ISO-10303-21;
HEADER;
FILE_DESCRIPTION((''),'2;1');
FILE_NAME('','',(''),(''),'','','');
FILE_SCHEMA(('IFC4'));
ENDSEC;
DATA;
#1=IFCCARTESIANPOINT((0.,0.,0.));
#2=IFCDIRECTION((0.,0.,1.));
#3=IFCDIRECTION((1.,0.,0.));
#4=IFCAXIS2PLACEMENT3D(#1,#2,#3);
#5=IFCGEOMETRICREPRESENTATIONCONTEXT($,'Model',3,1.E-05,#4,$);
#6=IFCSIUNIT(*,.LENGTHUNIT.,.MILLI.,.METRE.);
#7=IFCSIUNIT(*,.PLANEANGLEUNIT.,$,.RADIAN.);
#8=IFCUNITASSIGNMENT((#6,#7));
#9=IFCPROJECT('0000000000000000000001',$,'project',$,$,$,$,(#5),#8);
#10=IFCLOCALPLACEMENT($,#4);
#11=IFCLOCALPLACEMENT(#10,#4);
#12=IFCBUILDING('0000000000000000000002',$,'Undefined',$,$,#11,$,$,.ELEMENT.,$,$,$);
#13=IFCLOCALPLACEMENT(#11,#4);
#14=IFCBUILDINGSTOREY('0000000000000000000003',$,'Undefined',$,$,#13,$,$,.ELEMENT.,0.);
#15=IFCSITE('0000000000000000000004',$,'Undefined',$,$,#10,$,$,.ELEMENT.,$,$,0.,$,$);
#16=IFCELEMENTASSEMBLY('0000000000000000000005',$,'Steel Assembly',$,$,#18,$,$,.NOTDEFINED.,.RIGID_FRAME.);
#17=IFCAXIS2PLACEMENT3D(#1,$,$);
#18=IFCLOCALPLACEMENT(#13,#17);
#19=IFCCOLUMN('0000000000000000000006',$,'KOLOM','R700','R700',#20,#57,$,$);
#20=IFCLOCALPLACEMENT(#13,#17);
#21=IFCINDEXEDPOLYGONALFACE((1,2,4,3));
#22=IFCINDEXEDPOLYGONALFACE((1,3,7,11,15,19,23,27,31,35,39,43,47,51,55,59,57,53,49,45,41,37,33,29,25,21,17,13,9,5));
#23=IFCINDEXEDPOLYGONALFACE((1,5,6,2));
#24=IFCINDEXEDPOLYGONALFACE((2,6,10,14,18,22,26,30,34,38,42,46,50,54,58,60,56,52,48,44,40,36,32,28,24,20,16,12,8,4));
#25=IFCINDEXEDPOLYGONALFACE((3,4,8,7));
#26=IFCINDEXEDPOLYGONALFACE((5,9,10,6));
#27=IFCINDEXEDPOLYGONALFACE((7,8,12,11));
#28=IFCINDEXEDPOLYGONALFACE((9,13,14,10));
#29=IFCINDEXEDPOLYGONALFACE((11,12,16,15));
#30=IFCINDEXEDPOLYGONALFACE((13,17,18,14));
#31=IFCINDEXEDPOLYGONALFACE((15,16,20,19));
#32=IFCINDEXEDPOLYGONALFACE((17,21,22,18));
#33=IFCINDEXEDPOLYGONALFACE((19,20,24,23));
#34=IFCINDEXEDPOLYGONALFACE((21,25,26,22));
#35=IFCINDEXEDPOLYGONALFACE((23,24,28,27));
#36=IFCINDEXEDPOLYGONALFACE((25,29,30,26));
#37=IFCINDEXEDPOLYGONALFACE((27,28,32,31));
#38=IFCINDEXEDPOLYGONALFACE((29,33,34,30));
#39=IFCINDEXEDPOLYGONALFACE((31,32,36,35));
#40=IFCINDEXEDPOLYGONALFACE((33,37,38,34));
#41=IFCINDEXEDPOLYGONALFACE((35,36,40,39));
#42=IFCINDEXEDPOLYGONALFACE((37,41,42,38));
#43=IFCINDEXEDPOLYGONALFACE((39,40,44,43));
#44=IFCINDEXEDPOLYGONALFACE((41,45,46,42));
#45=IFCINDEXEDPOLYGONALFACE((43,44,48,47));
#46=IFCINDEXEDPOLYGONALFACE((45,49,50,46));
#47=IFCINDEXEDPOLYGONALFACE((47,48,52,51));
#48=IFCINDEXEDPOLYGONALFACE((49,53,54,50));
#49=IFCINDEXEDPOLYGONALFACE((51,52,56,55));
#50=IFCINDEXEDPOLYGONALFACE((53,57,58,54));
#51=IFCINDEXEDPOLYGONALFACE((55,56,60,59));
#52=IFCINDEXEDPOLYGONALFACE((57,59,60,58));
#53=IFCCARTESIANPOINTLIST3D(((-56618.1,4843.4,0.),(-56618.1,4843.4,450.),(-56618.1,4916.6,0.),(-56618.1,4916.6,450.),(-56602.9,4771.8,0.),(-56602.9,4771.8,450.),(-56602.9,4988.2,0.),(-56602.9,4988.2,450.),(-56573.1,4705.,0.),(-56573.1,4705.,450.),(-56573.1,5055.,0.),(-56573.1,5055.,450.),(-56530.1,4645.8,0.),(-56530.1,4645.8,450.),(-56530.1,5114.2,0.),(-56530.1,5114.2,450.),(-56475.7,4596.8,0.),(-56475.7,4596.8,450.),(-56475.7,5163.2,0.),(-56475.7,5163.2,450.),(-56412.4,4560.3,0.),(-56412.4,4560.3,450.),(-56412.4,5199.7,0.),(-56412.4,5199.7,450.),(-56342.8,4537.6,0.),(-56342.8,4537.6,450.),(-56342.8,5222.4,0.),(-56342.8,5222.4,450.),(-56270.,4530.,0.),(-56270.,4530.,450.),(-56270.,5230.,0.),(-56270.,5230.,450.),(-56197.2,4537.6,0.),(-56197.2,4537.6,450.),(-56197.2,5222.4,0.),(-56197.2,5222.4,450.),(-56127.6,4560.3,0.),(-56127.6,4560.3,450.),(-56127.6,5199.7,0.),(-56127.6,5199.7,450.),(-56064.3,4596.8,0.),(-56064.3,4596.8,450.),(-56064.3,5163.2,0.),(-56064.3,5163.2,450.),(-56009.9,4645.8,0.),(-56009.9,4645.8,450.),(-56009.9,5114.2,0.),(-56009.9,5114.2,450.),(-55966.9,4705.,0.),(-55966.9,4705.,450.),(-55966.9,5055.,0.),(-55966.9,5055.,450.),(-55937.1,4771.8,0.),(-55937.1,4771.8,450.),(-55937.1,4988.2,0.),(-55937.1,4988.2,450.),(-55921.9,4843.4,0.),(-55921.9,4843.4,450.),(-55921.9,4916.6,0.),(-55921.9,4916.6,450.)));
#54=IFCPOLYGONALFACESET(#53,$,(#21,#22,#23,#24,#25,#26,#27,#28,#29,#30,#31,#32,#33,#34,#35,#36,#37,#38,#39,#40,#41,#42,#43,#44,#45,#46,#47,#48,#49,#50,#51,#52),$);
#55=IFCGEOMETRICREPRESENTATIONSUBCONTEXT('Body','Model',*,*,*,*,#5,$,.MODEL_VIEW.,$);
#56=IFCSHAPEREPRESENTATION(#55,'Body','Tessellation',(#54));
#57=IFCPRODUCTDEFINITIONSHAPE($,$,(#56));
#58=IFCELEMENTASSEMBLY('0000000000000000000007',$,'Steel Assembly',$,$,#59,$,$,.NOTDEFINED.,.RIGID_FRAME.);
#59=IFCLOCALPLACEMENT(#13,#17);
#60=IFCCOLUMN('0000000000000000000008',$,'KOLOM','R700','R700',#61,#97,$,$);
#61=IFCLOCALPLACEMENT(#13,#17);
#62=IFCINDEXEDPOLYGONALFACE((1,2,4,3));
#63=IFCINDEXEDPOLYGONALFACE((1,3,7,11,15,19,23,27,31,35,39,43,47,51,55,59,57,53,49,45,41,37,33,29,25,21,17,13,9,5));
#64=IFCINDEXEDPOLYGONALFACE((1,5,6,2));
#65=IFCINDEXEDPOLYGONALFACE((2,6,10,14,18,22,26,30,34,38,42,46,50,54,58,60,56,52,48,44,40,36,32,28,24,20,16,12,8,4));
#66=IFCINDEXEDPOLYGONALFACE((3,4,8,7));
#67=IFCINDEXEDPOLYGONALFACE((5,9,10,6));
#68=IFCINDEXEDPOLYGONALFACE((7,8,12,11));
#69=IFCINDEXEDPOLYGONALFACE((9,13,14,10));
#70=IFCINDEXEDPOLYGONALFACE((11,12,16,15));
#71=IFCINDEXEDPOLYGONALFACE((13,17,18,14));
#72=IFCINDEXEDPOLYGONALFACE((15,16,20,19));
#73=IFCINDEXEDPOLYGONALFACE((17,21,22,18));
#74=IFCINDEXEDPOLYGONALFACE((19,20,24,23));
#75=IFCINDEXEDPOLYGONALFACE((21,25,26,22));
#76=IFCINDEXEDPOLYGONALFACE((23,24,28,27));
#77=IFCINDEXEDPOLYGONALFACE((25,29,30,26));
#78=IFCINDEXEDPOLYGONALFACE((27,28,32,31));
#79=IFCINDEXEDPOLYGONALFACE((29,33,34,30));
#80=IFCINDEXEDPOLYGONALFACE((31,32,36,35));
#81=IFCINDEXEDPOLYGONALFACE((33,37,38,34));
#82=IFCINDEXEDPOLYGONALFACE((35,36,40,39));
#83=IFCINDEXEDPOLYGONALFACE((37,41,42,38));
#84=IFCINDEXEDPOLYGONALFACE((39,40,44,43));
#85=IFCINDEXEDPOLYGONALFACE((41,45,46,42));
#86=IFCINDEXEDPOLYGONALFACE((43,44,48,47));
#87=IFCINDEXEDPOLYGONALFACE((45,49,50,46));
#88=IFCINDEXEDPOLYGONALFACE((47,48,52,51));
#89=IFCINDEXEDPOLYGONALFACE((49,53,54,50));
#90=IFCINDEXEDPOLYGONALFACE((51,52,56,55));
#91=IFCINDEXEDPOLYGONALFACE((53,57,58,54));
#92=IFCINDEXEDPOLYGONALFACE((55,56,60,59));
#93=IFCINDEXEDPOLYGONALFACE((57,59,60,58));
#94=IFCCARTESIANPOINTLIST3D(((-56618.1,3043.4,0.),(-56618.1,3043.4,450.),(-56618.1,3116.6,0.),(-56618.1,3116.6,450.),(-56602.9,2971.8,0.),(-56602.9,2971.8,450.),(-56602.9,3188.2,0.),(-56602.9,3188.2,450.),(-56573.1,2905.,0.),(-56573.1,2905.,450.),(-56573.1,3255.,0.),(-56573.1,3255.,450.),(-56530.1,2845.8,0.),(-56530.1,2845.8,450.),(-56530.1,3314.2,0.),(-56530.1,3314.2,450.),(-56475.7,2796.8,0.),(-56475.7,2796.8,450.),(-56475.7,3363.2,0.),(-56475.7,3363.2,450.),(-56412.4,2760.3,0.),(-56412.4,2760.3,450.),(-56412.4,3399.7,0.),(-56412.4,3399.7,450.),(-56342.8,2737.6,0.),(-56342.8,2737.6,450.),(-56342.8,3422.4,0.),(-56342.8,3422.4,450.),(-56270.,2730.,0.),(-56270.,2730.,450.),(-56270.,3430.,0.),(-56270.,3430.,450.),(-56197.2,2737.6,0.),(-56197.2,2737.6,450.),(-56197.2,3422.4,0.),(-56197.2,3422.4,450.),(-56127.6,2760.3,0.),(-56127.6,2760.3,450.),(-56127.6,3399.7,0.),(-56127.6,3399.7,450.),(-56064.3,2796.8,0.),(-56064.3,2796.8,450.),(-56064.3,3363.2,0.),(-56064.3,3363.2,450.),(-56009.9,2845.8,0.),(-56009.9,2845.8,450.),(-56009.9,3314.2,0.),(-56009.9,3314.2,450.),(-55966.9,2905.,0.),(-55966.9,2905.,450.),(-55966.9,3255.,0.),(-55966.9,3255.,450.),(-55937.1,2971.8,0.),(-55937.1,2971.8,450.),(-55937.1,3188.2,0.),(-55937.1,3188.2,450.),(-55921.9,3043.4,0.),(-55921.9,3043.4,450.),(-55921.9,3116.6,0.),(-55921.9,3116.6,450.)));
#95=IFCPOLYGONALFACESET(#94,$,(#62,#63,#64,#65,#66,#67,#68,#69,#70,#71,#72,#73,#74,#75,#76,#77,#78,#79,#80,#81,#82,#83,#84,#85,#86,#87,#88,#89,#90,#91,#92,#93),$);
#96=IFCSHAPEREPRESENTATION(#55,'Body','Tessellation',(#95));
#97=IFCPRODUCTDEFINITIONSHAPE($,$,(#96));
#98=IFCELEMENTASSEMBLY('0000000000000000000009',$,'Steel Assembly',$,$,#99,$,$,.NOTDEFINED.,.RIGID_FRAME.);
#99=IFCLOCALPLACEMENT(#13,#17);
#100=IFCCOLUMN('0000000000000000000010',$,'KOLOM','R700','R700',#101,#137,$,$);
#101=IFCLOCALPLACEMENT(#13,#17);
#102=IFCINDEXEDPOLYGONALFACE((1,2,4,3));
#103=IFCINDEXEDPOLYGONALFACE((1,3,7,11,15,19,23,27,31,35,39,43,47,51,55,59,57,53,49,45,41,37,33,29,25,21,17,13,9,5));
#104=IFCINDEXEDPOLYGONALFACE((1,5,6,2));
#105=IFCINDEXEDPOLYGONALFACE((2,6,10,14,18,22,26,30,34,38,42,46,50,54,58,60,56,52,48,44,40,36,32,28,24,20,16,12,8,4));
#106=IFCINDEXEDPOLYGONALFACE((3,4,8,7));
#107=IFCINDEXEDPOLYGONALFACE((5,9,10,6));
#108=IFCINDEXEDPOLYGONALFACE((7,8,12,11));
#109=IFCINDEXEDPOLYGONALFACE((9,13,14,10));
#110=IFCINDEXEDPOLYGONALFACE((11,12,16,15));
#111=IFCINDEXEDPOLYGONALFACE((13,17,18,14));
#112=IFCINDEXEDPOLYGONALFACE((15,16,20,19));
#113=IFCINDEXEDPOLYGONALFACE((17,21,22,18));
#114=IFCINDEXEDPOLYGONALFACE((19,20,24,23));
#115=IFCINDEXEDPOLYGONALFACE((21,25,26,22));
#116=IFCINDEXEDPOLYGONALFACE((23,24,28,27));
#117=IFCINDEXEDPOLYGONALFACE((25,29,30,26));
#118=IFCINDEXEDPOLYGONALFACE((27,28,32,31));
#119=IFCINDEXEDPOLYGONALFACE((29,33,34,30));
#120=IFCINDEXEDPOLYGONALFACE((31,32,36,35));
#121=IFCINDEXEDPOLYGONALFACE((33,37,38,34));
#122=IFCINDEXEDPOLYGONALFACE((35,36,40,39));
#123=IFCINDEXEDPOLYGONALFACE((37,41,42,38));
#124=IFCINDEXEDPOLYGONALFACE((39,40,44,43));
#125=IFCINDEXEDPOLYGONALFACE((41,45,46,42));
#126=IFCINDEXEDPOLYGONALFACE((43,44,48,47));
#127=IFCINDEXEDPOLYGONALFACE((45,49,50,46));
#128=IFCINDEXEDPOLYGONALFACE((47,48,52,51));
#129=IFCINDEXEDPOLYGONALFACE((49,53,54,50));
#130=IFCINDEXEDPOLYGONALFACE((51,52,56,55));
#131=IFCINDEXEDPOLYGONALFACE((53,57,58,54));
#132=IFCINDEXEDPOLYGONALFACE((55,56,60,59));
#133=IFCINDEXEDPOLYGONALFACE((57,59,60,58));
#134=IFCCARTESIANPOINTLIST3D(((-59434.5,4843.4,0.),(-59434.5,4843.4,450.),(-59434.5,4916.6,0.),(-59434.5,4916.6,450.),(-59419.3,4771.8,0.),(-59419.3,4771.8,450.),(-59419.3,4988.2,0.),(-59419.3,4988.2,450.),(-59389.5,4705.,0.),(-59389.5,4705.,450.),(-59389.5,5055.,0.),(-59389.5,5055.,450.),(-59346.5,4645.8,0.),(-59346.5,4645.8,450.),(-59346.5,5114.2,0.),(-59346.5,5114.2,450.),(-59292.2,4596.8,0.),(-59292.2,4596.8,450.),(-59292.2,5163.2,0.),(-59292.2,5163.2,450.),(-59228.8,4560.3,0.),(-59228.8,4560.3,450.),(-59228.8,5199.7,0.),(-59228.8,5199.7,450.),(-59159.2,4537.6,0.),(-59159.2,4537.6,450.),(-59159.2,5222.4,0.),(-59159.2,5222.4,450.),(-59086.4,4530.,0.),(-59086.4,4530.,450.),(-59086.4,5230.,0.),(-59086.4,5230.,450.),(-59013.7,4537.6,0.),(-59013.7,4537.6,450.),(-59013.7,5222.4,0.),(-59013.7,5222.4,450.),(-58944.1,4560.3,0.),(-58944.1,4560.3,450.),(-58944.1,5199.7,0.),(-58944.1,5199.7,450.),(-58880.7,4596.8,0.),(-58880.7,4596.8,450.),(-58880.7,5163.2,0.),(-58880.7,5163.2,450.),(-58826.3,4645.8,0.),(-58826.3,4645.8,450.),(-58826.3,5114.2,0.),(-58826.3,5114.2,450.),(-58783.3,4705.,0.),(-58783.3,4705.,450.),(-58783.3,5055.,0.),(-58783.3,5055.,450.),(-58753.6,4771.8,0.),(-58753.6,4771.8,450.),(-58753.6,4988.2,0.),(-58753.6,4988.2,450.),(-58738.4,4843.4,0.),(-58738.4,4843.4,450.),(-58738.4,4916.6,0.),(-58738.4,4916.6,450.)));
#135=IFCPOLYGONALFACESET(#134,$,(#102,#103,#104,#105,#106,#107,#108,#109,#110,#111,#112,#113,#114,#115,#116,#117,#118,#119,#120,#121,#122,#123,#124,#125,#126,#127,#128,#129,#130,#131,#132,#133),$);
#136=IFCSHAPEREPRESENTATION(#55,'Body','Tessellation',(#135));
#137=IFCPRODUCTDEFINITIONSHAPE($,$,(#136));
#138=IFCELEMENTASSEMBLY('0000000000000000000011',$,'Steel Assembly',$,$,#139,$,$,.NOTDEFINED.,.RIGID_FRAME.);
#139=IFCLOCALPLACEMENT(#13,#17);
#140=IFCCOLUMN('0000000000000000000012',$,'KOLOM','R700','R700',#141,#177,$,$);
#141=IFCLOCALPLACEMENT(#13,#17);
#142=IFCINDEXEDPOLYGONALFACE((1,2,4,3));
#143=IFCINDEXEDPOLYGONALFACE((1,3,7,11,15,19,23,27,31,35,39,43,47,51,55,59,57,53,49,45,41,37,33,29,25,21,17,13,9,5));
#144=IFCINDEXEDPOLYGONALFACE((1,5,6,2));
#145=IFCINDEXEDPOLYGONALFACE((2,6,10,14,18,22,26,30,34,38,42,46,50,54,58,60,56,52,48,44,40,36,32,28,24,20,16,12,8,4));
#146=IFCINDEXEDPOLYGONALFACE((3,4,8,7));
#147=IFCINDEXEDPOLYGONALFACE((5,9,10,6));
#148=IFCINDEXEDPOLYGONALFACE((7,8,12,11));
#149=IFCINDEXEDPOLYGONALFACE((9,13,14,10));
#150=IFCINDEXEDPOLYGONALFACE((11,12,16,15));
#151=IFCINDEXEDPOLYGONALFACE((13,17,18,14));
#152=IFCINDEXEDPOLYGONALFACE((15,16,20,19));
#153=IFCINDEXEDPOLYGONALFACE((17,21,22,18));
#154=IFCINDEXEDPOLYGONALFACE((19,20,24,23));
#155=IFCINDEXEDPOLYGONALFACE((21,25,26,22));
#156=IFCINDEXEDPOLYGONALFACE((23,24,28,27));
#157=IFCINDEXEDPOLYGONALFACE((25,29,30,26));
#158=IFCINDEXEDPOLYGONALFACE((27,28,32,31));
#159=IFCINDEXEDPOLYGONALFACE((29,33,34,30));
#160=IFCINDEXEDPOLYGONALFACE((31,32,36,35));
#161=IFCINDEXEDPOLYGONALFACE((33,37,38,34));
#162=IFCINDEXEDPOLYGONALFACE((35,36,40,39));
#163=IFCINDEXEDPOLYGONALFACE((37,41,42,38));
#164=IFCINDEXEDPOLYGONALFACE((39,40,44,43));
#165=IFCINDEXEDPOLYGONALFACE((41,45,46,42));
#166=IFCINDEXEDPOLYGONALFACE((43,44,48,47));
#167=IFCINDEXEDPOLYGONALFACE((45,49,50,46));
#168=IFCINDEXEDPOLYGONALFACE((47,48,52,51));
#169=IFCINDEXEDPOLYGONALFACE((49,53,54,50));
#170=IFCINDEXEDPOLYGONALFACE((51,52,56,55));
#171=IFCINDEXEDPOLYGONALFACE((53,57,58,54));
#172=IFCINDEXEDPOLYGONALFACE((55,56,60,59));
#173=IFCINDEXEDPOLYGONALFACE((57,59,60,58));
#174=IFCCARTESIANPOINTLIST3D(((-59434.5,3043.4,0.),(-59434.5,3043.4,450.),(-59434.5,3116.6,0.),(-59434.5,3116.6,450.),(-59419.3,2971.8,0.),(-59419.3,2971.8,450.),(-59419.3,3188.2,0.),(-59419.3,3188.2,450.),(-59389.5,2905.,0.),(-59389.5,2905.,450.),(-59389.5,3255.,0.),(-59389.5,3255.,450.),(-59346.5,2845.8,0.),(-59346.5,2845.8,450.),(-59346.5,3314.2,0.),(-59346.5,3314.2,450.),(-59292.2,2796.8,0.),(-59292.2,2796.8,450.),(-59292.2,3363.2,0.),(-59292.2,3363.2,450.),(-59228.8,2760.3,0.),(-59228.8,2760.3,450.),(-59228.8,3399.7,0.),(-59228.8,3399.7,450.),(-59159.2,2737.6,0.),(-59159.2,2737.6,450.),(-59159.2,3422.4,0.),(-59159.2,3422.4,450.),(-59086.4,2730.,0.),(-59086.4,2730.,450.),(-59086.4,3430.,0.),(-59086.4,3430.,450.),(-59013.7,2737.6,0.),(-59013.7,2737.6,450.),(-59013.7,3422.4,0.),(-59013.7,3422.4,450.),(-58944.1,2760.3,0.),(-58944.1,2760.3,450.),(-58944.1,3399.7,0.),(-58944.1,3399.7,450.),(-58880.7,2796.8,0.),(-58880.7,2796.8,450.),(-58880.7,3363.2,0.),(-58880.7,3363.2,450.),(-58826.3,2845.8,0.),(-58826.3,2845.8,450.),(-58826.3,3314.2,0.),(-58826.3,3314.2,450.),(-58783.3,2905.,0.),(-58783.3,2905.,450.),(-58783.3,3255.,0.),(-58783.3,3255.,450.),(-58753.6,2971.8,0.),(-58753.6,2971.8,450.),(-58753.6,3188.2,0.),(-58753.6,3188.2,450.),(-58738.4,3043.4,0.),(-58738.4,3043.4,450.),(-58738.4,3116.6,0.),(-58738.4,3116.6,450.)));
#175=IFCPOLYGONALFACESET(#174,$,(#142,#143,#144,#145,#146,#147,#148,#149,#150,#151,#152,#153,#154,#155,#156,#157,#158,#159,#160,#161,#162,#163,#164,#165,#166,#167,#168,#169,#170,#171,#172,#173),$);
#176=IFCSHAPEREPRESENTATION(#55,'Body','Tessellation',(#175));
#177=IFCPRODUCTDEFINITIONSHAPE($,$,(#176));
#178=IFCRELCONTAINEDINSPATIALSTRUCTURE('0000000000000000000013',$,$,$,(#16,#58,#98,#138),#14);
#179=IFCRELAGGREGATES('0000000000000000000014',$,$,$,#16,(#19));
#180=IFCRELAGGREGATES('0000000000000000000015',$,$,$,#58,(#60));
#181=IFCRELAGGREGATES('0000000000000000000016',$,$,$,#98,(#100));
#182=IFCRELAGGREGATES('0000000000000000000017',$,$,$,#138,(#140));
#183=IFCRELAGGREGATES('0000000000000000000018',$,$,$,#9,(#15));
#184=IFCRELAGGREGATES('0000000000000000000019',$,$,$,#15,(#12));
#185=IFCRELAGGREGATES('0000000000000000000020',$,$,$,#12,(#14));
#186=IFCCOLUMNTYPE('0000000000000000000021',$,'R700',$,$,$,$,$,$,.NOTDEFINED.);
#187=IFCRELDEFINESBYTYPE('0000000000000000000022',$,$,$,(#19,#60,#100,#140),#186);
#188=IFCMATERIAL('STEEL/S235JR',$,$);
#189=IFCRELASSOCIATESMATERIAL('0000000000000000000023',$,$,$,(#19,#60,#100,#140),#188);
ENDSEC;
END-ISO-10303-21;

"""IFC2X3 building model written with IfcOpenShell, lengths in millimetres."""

from ifc_helpers import new_model, si_unit, frame, origin_with_axes, origin_2d_with_axis, place, context, subcontext, project, spatial, circle, extrude, material, type_object, element, aggregate, save


model = new_model("IFC2X3")

# Units and contexts
model_context = context("Model", 3, precision=1e-05, world=origin_with_axes())
body_context = subcontext(model_context, "Body", "Model", "MODEL_VIEW")
ifc_project = project(units=[si_unit("LENGTHUNIT", "METRE", prefix="MILLI"), si_unit("PLANEANGLEUNIT", "RADIAN")], contexts=[model_context])

# Site, building, storey
site_placement = place(None, origin_with_axes())
site = spatial("IfcSite", under=ifc_project, at=site_placement, Name="Undefined", CompositionType="ELEMENT", RefElevation=0.0)
building_placement = place(site_placement, origin_with_axes())
building = spatial("IfcBuilding", under=site, at=building_placement, Name="Undefined", CompositionType="ELEMENT")
storey_placement = place(building_placement, origin_with_axes())
storey = spatial("IfcBuildingStorey", under=building, at=storey_placement, Name="Undefined", CompositionType="ELEMENT", Elevation=0.0)

# Element assemblies, columns
ifc_material = material(Name="STEEL/S235JR")
column_type = type_object("IfcColumnType", Name="R700", PredefinedType="NOTDEFINED")
assembly_1_placement = place(storey_placement, origin_with_axes())
assembly_1 = element("IfcElementAssembly", 1, at=assembly_1_placement, inside=storey, Name="Steel Assembly", AssemblyPlace="NOTDEFINED", PredefinedType="RIGID_FRAME")
column_1_placement = place(assembly_1_placement, frame((-56270.0, 4880.0, 0.0), z_axis=(0.0, 0.0, 1.0), x_axis=(-1.0, 0.0, 0.0)))
column_1 = element("IfcColumn", 2, at=column_1_placement, type_object=column_type, material=ifc_material, Name="KOLOM", Description="R700", ObjectType="R700", context=body_context, shape_type="SweptSolid", body=[
    extrude(circle(Radius=350.0, at=origin_2d_with_axis()), frame((0.0, 0.0, 450.0), z_axis=(0.0, 0.0, -1.0), x_axis=(0.0, 1.0, 0.0)), (0.0, 0.0, 1.0), 450.0),
])
aggregate(assembly_1, [column_1])
assembly_2_placement = place(storey_placement, origin_with_axes())
assembly_2 = element("IfcElementAssembly", 3, at=assembly_2_placement, inside=storey, Name="Steel Assembly", AssemblyPlace="NOTDEFINED", PredefinedType="RIGID_FRAME")
column_2_placement = place(assembly_2_placement, frame((-56270.0, 3080.0, 0.0), z_axis=(0.0, 0.0, 1.0), x_axis=(-1.0, 0.0, 0.0)))
column_2 = element("IfcColumn", 4, at=column_2_placement, type_object=column_type, material=ifc_material, Name="KOLOM", Description="R700", ObjectType="R700", context=body_context, shape_type="SweptSolid", body=[
    extrude(circle(Radius=350.0, at=origin_2d_with_axis()), frame((0.0, 0.0, 450.0), z_axis=(0.0, 0.0, -1.0), x_axis=(0.0, 1.0, 0.0)), (0.0, 0.0, 1.0), 450.0),
])
aggregate(assembly_2, [column_2])
assembly_3_placement = place(storey_placement, origin_with_axes())
assembly_3 = element("IfcElementAssembly", 5, at=assembly_3_placement, inside=storey, Name="Steel Assembly", AssemblyPlace="NOTDEFINED", PredefinedType="RIGID_FRAME")
column_3_placement = place(assembly_3_placement, frame((-59086.4, 4880.0, 0.0), z_axis=(0.0, 0.0, 1.0), x_axis=(-1.0, 0.0, 0.0)))
column_3 = element("IfcColumn", 6, at=column_3_placement, type_object=column_type, material=ifc_material, Name="KOLOM", Description="R700", ObjectType="R700", context=body_context, shape_type="SweptSolid", body=[
    extrude(circle(Radius=350.0, at=origin_2d_with_axis()), frame((0.0, 0.0, 450.0), z_axis=(0.0, 0.0, -1.0), x_axis=(0.0, 1.0, 0.0)), (0.0, 0.0, 1.0), 450.0),
])
aggregate(assembly_3, [column_3])
assembly_4_placement = place(storey_placement, origin_with_axes())
assembly_4 = element("IfcElementAssembly", 7, at=assembly_4_placement, inside=storey, Name="Steel Assembly", AssemblyPlace="NOTDEFINED", PredefinedType="RIGID_FRAME")
column_4_placement = place(assembly_4_placement, frame((-59086.4, 3080.0, 0.0), z_axis=(0.0, 0.0, 1.0), x_axis=(-1.0, 0.0, 0.0)))
column_4 = element("IfcColumn", 8, at=column_4_placement, type_object=column_type, material=ifc_material, Name="KOLOM", Description="R700", ObjectType="R700", context=body_context, shape_type="SweptSolid", body=[
    extrude(circle(Radius=350.0, at=origin_2d_with_axis()), frame((0.0, 0.0, 450.0), z_axis=(0.0, 0.0, -1.0), x_axis=(0.0, 1.0, 0.0)), (0.0, 0.0, 1.0), 450.0),
])
aggregate(assembly_4, [column_4])

save(model, "model.ifc")
